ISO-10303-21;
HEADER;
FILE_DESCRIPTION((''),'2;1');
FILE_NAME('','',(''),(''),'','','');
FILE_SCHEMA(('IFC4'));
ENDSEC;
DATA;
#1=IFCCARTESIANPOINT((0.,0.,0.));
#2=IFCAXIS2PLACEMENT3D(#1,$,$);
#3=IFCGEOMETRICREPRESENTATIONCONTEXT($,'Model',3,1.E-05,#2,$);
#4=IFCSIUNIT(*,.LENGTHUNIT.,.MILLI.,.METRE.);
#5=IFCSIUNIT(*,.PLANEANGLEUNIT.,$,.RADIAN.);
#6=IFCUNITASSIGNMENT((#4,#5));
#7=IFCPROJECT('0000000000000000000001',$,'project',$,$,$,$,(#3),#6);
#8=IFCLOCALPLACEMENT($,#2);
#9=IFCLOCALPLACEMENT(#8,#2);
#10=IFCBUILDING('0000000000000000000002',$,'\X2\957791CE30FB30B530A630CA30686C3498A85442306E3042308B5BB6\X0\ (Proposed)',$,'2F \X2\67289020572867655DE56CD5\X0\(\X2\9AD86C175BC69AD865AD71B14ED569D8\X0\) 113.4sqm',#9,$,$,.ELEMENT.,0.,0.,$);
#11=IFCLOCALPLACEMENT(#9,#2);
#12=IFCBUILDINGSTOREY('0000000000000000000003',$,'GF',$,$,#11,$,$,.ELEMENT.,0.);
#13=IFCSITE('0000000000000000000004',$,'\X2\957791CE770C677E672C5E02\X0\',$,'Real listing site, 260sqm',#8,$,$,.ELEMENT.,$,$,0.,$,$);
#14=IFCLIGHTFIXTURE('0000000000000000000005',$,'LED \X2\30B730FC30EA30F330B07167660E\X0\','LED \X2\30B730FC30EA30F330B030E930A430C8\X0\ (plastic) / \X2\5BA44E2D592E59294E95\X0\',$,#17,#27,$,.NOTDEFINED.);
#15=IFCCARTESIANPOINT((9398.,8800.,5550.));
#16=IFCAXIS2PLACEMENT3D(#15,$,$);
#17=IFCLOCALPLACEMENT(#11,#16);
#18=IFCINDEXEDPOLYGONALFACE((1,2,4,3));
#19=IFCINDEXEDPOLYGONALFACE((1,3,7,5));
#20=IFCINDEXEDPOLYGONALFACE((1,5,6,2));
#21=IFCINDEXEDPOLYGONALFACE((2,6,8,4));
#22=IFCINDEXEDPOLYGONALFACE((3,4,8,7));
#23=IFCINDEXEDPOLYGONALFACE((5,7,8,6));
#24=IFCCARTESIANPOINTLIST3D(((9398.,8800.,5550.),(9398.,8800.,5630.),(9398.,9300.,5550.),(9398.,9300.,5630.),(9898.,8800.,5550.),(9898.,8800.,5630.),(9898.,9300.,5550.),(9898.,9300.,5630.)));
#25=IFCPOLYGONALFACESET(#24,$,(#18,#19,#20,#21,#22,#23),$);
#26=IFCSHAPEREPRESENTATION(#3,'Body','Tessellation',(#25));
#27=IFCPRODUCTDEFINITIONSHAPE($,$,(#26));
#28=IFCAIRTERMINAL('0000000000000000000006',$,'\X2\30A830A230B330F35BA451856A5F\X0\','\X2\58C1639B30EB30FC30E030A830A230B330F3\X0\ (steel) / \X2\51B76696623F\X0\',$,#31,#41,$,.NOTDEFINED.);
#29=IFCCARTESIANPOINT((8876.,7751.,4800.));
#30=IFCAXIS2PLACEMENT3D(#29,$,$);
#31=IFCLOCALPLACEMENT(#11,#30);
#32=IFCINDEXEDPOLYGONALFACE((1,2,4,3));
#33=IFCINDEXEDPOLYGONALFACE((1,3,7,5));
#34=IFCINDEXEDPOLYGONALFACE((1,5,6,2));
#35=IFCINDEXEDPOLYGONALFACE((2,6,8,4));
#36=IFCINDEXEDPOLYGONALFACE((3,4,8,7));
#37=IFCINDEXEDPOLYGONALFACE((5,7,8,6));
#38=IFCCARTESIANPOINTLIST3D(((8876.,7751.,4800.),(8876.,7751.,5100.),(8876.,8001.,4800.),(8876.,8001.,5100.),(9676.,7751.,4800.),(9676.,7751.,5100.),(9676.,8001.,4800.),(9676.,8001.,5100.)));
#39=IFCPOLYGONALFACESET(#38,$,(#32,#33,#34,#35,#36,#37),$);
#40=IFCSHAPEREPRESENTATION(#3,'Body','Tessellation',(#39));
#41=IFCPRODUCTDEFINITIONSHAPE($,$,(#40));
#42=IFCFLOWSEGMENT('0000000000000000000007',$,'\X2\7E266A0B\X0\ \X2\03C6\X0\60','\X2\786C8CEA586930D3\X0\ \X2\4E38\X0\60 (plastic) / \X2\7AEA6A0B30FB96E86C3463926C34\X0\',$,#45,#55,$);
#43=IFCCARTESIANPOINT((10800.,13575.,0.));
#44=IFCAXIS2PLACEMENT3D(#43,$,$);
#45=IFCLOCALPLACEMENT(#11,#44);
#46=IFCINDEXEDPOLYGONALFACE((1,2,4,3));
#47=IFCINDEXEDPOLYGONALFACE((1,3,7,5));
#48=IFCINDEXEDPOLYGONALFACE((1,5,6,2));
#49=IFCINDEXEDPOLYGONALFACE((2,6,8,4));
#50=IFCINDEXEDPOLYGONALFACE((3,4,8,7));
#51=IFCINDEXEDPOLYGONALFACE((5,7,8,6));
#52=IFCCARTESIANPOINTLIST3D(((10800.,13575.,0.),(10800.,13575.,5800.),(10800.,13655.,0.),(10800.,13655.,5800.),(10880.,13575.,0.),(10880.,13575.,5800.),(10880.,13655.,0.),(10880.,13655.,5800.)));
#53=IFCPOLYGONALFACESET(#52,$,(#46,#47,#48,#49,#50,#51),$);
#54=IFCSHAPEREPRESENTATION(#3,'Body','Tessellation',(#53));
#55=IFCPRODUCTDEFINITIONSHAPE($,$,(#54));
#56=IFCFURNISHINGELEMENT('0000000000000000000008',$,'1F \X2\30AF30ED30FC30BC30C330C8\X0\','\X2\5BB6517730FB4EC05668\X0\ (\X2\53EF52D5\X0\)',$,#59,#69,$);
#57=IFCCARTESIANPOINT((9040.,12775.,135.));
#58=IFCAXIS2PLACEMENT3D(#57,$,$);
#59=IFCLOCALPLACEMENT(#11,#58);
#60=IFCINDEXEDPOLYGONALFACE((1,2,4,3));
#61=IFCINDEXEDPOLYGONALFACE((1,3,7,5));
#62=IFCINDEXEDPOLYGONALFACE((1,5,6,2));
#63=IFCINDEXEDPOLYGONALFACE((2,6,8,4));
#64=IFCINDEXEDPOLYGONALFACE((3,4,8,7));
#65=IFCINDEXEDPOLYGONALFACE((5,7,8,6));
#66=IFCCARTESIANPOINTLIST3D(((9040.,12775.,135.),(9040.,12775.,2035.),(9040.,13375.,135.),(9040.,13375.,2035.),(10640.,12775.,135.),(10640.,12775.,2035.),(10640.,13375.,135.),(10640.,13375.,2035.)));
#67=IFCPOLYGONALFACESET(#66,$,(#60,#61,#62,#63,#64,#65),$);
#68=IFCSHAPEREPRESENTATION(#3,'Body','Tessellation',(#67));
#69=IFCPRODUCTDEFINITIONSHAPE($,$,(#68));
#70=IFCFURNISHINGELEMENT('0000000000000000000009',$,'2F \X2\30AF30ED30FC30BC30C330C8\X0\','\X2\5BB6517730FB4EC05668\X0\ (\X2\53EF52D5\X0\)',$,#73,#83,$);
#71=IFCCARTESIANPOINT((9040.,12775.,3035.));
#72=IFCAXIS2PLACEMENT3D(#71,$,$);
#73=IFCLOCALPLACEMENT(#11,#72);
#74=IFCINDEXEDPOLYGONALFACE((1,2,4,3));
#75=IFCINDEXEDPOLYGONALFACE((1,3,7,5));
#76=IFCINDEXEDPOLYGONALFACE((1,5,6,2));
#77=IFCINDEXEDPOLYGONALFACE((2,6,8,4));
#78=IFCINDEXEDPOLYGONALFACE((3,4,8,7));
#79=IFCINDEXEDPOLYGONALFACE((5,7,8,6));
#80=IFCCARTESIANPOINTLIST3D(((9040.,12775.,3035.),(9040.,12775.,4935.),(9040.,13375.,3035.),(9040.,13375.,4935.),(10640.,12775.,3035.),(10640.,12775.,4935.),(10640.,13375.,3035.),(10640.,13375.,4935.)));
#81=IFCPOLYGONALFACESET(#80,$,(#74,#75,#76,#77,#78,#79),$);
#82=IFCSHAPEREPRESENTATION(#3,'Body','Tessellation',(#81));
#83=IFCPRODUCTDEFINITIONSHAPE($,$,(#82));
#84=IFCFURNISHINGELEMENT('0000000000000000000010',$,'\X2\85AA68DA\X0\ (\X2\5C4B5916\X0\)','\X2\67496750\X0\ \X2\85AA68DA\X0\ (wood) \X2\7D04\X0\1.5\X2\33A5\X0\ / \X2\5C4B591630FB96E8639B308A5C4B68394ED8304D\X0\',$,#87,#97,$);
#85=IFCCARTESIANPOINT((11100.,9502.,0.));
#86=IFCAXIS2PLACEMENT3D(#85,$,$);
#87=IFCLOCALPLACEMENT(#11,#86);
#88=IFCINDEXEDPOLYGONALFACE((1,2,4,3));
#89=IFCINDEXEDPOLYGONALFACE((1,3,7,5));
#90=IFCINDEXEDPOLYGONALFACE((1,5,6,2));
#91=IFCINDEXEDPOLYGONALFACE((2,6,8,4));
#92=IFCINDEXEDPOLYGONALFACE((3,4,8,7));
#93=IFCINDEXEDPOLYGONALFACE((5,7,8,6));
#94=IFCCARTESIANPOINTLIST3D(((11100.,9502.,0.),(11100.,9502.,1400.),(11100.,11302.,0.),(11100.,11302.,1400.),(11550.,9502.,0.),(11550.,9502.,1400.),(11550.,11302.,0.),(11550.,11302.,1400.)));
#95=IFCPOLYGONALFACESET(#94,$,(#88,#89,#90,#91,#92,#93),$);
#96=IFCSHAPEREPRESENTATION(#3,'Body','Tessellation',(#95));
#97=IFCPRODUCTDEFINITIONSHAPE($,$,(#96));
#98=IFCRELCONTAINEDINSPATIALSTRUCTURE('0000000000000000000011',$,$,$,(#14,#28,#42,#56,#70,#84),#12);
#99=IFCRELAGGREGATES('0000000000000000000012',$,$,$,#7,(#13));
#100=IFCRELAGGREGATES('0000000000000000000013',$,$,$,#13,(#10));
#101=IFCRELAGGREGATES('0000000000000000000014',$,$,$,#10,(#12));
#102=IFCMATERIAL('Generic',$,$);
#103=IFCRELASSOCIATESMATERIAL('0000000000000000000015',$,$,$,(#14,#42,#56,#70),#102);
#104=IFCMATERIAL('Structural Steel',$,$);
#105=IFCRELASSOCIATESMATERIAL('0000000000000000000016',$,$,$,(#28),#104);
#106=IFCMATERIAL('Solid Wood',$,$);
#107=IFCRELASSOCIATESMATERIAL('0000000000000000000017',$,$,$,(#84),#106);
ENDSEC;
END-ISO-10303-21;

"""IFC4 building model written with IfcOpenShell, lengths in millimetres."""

from ifc_helpers import new_model, si_unit, frame, frame_2d, origin, place, context, project, spatial, rectangle, extrude, material, element, save


model = new_model("IFC4")

# Units and contexts
model_context = context("Model", 3, precision=1e-05, world=origin())
ifc_project = project(units=[si_unit("LENGTHUNIT", "METRE", prefix="MILLI"), si_unit("PLANEANGLEUNIT", "RADIAN")], contexts=[model_context])

# Site, building, storey
site_placement = place(None, origin())
site = spatial("IfcSite", under=ifc_project, at=site_placement, Name="長野県松本市", ObjectType="Real listing site, 260sqm", CompositionType="ELEMENT", RefElevation=0.0)
building_placement = place(site_placement, origin())
building = spatial("IfcBuilding", under=site, at=building_placement, Name="長野・サウナと水風呂のある家 (Proposed)", ObjectType="2F 木造在来工法(高気密高断熱仕様) 113.4sqm", CompositionType="ELEMENT", ElevationOfRefHeight=0.0, ElevationOfTerrain=0.0)
storey_placement = place(building_placement, origin())
storey = spatial("IfcBuildingStorey", under=building, at=storey_placement, Name="GF", CompositionType="ELEMENT", Elevation=0.0)

# Shared definitions
ifc_material_1 = material(Name="Solid Wood")
ifc_material_2 = material(Name="Structural Steel")

# Light fixture
ifc_material_3 = material(Name="Generic")
light_fixture_1_placement = place(storey_placement, frame((9398.0, 8800.0, 5550.0)))
element("IfcLightFixture", 1, at=light_fixture_1_placement, inside=storey, material=ifc_material_3, Name="LED シーリング照明", Description="LED シーリングライト (plastic) / 室中央天井", PredefinedType="NOTDEFINED", context=model_context, shape_type="SweptSolid", body=[
    extrude(rectangle(XDim=500.0, YDim=500.0, at=frame_2d((250.0, 250.0))), frame((9398.0, 8800.0, 5550.0)), (0.0, 0.0, 1.0), 80.0),
])

# Air terminal
air_terminal_placement = place(storey_placement, frame((8876.0, 7751.0, 4800.0)))
element("IfcAirTerminal", 2, at=air_terminal_placement, inside=storey, material=ifc_material_2, Name="エアコン室内機", Description="壁掛ルームエアコン (steel) / 冷暖房", PredefinedType="NOTDEFINED", context=model_context, shape_type="SweptSolid", body=[
    extrude(rectangle(XDim=800.0, YDim=250.0, at=frame_2d((400.0, 125.0))), frame((8876.0, 7751.0, 4800.0)), (0.0, 0.0, 1.0), 300.0),
])

# Flow segment
flow_segment_placement = place(storey_placement, frame((10800.0, 13575.0, 0.0)))
element("IfcFlowSegment", 3, at=flow_segment_placement, inside=storey, material=ifc_material_3, Name="縦樋 φ60", Description="硬質塩ビ 丸60 (plastic) / 竪樋・雨水排水", context=model_context, shape_type="SweptSolid", body=[
    extrude(rectangle(XDim=80.0, YDim=80.0, at=frame_2d((40.0, 40.0))), frame((10800.0, 13575.0, 0.0)), (0.0, 0.0, 1.0), 5800.0),
])

# Furnishing elements
furnishing_1_placement = place(storey_placement, frame((9040.0, 12775.0, 135.0)))
element("IfcFurnishingElement", 4, at=furnishing_1_placement, inside=storey, material=ifc_material_3, Name="1F クローゼット", Description="家具・什器 (可動)", context=model_context, shape_type="SweptSolid", body=[
    extrude(rectangle(XDim=1600.0, YDim=600.0, at=frame_2d((800.0, 300.0))), frame((9040.0, 12775.0, 135.0)), (0.0, 0.0, 1.0), 1900.0),
])
furnishing_2_placement = place(storey_placement, frame((9040.0, 12775.0, 3035.0)))
element("IfcFurnishingElement", 5, at=furnishing_2_placement, inside=storey, material=ifc_material_3, Name="2F クローゼット", Description="家具・什器 (可動)", context=model_context, shape_type="SweptSolid", body=[
    extrude(rectangle(XDim=1600.0, YDim=600.0, at=frame_2d((800.0, 300.0))), frame((9040.0, 12775.0, 3035.0)), (0.0, 0.0, 1.0), 1900.0),
])
furnishing_3_placement = place(storey_placement, frame((11100.0, 9502.0, 0.0)))
element("IfcFurnishingElement", 6, at=furnishing_3_placement, inside=storey, material=ifc_material_1, Name="薪棚 (屋外)", Description="杉材 薪棚 (wood) 約1.5㎥ / 屋外・雨掛り屋根付き", context=model_context, shape_type="SweptSolid", body=[
    extrude(rectangle(XDim=450.0, YDim=1800.0, at=frame_2d((225.0, 900.0))), frame((11100.0, 9502.0, 0.0)), (0.0, 0.0, 1.0), 1400.0),
])

save(model, "model.ifc")
